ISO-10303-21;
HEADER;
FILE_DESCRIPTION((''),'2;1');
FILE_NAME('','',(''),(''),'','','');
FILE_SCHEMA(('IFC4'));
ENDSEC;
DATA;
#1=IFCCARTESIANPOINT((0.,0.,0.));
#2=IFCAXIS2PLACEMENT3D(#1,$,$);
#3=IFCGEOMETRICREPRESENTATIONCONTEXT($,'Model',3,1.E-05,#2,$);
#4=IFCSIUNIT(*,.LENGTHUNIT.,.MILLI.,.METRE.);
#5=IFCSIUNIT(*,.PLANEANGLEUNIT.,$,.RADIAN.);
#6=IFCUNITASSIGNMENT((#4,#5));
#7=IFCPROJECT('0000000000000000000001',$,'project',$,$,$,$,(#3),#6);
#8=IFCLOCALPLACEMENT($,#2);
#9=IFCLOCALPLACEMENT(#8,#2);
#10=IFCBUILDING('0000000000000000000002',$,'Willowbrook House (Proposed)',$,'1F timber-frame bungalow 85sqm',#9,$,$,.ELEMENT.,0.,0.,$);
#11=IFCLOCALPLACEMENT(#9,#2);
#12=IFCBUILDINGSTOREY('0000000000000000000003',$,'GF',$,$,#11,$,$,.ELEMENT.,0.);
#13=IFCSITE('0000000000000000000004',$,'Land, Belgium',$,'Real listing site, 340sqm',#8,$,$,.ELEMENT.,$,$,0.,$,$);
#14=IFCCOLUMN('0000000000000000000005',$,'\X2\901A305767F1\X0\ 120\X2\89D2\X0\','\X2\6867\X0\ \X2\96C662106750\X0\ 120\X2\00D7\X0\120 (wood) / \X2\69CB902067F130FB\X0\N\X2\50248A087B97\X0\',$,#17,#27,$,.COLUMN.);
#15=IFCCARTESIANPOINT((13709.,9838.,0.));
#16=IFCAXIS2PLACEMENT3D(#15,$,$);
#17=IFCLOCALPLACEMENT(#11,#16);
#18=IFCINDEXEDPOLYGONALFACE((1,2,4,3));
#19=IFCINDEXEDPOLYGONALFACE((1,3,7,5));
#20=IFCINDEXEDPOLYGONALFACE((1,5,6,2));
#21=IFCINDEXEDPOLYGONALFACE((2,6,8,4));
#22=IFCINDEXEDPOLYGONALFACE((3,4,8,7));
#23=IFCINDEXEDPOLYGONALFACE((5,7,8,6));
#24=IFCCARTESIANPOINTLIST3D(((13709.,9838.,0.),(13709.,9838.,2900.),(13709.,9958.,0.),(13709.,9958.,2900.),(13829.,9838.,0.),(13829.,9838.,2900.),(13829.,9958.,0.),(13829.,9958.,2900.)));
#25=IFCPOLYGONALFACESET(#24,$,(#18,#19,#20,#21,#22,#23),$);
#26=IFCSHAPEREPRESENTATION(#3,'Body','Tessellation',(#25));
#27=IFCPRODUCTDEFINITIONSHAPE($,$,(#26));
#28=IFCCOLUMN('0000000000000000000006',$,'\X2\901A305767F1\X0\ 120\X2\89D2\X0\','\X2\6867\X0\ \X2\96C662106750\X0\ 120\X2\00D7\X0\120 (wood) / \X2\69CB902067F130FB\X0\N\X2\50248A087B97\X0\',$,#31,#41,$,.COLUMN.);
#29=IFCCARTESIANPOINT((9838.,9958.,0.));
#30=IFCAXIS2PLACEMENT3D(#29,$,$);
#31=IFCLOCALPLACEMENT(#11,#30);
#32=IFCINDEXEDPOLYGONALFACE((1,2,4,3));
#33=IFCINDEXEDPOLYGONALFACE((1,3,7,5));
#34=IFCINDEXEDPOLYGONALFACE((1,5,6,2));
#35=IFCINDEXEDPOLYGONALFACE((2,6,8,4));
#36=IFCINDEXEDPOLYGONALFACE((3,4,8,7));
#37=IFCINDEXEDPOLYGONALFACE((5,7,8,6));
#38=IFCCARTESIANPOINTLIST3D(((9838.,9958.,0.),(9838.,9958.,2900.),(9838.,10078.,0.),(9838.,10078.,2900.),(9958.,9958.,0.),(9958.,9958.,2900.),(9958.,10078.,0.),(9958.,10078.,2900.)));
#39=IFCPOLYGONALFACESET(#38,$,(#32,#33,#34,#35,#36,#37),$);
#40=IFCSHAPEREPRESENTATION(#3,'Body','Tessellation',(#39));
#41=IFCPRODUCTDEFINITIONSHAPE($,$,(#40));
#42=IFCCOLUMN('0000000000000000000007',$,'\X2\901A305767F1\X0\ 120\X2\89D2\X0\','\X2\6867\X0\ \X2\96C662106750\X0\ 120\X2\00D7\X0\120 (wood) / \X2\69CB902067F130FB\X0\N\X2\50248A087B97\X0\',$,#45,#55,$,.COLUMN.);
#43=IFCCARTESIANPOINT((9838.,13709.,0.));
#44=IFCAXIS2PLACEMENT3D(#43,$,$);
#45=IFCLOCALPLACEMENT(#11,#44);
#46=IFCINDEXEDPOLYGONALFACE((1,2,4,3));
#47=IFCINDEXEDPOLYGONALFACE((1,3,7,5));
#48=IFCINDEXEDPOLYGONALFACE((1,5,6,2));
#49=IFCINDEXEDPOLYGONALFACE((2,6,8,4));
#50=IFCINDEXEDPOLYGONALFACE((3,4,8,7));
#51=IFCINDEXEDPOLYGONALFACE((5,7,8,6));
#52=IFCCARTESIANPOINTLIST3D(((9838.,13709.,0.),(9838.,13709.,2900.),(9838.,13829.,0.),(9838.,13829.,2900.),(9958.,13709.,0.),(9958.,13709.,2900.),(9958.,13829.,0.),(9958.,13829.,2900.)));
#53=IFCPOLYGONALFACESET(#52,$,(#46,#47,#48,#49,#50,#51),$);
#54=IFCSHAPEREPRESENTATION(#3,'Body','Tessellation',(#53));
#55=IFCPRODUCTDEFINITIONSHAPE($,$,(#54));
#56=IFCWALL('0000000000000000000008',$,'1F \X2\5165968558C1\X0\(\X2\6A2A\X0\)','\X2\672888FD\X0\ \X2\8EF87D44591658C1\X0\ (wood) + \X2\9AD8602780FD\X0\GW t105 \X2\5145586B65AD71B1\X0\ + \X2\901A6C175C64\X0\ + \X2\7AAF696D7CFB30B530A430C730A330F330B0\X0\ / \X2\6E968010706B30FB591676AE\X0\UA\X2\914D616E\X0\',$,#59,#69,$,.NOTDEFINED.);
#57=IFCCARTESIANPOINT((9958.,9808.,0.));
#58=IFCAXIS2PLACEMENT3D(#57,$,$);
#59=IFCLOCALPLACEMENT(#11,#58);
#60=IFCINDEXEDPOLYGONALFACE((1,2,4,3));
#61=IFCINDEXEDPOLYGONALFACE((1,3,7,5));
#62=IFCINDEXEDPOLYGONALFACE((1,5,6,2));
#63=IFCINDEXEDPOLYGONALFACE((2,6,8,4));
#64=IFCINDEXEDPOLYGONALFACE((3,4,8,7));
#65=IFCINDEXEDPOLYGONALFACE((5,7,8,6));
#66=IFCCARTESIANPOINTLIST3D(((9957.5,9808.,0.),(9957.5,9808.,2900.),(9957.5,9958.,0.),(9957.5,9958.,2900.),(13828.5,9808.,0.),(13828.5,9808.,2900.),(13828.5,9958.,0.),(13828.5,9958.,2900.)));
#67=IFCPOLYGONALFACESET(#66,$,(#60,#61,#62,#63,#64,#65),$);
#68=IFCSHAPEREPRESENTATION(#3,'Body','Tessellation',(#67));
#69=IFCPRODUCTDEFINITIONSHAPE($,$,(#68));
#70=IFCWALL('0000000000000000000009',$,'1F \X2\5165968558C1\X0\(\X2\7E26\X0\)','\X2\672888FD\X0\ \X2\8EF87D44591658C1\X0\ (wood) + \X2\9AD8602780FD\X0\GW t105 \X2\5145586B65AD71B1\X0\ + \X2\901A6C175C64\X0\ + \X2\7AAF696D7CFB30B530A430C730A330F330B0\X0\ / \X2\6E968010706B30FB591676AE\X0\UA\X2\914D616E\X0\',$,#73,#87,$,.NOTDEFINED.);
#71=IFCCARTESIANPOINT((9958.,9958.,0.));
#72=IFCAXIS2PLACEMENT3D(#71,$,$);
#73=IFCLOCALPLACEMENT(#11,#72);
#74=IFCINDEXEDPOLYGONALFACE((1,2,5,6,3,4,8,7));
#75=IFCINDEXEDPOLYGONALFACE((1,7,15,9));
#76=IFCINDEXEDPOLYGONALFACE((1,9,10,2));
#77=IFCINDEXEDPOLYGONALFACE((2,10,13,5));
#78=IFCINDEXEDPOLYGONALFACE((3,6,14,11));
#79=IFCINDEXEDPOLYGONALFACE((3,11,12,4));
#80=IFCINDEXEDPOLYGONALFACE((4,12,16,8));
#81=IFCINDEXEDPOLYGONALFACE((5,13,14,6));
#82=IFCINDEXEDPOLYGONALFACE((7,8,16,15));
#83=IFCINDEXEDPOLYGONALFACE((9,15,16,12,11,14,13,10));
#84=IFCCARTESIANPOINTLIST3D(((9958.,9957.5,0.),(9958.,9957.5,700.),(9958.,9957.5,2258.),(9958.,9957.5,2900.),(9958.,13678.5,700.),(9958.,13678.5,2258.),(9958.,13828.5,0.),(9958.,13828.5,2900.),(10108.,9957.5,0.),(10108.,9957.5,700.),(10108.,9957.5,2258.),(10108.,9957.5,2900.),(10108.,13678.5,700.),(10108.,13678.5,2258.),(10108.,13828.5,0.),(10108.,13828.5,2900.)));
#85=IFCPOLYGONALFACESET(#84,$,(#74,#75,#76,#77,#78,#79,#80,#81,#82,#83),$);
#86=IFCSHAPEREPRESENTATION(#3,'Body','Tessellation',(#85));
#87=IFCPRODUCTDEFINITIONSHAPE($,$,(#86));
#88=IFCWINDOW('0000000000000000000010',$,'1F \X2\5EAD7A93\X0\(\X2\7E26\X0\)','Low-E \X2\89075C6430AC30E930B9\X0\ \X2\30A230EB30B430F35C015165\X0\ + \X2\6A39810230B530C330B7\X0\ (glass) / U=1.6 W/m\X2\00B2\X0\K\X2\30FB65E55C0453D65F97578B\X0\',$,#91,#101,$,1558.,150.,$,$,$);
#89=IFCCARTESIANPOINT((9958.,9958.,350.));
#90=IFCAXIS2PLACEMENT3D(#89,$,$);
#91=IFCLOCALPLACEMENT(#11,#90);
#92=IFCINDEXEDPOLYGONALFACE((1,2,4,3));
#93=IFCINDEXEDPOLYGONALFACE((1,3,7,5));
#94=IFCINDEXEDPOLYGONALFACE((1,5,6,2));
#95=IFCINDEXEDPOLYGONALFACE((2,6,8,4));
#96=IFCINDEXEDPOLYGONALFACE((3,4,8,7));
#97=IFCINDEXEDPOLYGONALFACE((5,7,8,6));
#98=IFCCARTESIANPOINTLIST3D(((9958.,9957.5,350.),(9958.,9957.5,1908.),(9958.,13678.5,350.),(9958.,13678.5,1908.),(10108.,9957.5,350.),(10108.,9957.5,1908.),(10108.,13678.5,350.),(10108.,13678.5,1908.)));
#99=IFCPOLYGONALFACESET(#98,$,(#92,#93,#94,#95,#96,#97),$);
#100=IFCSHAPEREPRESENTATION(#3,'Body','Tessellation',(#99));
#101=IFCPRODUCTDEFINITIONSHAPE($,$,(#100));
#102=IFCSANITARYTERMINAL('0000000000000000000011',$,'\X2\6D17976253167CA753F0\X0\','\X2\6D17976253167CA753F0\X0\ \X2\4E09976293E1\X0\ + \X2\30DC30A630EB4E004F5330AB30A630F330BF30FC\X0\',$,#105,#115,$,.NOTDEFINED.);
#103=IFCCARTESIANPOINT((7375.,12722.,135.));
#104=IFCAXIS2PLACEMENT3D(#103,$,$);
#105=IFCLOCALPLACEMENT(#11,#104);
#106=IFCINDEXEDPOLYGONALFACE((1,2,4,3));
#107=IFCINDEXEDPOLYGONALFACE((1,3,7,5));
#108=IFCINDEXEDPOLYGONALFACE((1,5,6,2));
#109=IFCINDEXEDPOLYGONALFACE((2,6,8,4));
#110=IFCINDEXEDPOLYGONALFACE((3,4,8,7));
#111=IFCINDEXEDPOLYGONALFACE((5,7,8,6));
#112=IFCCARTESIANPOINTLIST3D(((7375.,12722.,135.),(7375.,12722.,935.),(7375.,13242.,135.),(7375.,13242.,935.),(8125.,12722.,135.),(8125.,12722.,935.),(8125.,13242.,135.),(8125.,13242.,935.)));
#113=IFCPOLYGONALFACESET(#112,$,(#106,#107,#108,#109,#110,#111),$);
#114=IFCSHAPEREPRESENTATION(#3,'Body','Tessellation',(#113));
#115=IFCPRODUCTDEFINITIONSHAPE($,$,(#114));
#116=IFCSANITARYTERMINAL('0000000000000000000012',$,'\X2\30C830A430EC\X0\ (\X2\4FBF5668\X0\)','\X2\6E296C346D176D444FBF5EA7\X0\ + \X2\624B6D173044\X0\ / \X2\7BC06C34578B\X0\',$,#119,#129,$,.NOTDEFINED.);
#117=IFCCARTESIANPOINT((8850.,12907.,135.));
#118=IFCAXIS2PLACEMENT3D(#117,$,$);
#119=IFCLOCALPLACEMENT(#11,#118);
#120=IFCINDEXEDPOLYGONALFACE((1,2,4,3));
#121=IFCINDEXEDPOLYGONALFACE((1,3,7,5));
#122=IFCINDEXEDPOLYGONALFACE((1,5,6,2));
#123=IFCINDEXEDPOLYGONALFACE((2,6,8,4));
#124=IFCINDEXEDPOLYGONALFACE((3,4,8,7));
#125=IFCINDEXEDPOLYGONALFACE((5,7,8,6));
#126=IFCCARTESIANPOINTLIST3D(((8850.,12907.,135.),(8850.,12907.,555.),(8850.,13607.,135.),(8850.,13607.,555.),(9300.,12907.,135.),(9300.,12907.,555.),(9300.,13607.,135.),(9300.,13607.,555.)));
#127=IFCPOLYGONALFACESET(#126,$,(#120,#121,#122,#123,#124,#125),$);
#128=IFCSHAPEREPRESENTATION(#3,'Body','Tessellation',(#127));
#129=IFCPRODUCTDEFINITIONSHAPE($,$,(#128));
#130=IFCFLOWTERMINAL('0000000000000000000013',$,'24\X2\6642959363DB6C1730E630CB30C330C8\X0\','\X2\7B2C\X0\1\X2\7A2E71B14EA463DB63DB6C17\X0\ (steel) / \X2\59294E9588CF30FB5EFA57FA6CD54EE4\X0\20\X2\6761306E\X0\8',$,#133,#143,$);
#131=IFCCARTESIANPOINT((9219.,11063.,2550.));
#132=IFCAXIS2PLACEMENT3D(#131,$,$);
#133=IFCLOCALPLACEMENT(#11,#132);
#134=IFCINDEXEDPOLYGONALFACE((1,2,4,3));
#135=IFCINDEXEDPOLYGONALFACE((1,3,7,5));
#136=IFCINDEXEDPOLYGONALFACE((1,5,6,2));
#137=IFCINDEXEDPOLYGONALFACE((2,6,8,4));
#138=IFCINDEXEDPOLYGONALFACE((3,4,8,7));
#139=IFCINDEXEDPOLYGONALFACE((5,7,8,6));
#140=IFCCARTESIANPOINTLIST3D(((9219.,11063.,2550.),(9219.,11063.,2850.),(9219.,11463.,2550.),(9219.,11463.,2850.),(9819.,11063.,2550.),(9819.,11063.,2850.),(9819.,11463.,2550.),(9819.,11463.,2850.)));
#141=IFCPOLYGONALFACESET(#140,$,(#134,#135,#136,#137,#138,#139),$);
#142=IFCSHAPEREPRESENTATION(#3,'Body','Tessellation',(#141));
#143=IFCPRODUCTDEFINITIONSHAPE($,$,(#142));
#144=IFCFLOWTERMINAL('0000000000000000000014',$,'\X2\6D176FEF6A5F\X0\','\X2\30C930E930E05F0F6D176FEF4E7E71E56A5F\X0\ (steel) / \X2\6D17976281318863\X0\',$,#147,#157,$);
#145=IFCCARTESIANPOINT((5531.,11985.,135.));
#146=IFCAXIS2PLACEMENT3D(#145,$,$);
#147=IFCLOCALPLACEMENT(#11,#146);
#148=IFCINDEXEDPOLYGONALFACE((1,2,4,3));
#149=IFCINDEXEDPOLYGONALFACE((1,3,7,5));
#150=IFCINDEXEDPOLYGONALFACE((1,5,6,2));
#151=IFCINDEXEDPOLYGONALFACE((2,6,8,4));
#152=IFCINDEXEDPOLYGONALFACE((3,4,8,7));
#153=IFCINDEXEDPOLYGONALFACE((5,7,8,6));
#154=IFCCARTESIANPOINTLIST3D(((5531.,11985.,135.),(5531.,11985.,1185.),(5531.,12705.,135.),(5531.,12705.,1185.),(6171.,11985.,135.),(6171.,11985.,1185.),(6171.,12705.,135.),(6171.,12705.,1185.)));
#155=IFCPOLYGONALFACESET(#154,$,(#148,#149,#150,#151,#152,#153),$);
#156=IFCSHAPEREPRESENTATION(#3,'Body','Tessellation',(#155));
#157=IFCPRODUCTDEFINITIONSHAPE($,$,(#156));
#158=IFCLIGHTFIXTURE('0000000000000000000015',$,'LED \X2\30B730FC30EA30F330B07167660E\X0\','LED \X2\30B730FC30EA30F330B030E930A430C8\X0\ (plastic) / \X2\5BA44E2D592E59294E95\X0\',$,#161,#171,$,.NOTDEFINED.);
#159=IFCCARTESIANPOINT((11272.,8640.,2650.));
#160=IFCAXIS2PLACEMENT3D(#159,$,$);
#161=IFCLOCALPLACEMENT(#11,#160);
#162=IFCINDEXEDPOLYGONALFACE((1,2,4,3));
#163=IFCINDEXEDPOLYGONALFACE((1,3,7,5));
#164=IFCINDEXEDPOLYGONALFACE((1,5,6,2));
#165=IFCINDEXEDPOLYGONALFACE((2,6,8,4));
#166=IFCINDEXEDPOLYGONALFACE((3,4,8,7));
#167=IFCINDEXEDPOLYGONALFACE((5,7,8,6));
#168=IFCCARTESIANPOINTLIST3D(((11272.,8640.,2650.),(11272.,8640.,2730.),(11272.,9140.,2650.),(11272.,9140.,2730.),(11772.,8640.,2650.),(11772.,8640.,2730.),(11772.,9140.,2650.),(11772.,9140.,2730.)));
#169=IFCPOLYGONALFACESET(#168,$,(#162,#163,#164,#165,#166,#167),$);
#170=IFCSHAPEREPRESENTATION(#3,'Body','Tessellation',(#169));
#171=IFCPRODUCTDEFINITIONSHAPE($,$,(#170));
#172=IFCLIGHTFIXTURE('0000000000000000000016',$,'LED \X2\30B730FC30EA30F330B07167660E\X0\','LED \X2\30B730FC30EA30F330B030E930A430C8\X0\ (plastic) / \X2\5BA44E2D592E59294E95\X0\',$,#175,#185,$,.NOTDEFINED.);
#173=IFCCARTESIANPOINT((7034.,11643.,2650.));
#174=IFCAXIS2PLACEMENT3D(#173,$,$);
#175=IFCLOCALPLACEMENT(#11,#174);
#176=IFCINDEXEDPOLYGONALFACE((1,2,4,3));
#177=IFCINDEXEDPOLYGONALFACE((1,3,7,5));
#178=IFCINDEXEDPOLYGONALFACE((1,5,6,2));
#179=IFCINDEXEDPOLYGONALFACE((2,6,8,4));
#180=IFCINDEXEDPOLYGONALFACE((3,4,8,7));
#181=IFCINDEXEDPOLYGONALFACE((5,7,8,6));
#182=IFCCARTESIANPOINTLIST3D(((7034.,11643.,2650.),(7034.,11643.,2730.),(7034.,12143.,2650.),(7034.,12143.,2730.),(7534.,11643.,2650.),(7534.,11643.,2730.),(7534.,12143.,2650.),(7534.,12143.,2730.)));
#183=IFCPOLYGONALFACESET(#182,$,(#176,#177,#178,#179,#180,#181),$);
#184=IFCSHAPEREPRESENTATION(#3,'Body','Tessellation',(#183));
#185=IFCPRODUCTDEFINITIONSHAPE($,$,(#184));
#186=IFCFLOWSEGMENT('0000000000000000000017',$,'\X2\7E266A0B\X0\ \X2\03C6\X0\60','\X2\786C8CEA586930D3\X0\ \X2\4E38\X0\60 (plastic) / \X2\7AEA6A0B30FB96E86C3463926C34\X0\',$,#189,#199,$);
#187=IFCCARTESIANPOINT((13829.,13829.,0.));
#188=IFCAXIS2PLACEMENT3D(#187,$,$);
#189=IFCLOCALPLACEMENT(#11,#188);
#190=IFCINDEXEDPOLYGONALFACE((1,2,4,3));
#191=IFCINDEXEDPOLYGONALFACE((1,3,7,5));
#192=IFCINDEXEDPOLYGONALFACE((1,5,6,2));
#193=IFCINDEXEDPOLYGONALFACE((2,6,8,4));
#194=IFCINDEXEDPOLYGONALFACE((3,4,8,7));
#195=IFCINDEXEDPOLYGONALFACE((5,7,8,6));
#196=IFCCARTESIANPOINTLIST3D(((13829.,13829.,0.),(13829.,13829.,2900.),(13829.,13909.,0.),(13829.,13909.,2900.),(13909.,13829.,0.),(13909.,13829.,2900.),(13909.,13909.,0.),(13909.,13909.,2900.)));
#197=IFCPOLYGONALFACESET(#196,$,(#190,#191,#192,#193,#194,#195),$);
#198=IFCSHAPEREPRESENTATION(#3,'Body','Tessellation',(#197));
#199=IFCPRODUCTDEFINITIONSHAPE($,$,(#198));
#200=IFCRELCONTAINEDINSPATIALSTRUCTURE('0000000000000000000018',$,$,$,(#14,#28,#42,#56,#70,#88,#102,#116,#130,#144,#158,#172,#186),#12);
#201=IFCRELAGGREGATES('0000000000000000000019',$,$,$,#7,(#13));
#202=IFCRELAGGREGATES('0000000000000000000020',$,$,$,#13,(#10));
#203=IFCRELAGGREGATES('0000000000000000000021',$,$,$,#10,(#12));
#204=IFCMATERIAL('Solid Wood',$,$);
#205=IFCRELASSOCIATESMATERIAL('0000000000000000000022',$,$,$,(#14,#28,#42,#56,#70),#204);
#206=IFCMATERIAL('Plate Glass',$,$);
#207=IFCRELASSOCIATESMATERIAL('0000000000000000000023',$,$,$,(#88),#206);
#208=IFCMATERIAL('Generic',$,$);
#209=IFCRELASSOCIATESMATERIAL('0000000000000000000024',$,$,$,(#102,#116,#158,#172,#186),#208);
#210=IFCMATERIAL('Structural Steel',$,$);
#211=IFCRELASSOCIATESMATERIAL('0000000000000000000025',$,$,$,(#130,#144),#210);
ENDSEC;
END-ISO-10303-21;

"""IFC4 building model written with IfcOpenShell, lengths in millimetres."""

from ifc_helpers import new_model, si_unit, frame, frame_2d, origin, place, context, project, spatial, rectangle, extrude, material, element, fill, save


model = new_model("IFC4")

# Units and contexts
model_context = context("Model", 3, precision=1e-05, world=origin())
ifc_project = project(units=[si_unit("LENGTHUNIT", "METRE", prefix="MILLI"), si_unit("PLANEANGLEUNIT", "RADIAN")], contexts=[model_context])

# Site, building, storey
site_placement = place(None, origin())
site = spatial("IfcSite", under=ifc_project, at=site_placement, Name="Land, Belgium", ObjectType="Real listing site, 340sqm", CompositionType="ELEMENT", RefElevation=0.0)
building_placement = place(site_placement, origin())
building = spatial("IfcBuilding", under=site, at=building_placement, Name="Willowbrook House (Proposed)", ObjectType="1F timber-frame bungalow 85sqm", CompositionType="ELEMENT", ElevationOfRefHeight=0.0, ElevationOfTerrain=0.0)
storey_placement = place(building_placement, origin())
storey = spatial("IfcBuildingStorey", under=building, at=storey_placement, Name="GF", CompositionType="ELEMENT", Elevation=0.0)

# Columns
ifc_material_1 = material(Name="Solid Wood")
column_1_placement = place(storey_placement, frame((13709.0, 9838.0, 0.0)))
element("IfcColumn", 1, at=column_1_placement, inside=storey, material=ifc_material_1, Name="通し柱 120角", Description="桧 集成材 120×120 (wood) / 構造柱・N値計算", PredefinedType="COLUMN", context=model_context, shape_type="SweptSolid", body=[
    extrude(rectangle(XDim=120.0, YDim=120.0, at=frame_2d((60.0, 60.0))), frame((13709.0, 9838.0, 0.0)), (0.0, 0.0, 1.0), 2900.0),
])
column_2_placement = place(storey_placement, frame((9838.0, 9958.0, 0.0)))
element("IfcColumn", 2, at=column_2_placement, inside=storey, material=ifc_material_1, Name="通し柱 120角", Description="桧 集成材 120×120 (wood) / 構造柱・N値計算", PredefinedType="COLUMN", context=model_context, shape_type="SweptSolid", body=[
    extrude(rectangle(XDim=120.0, YDim=120.0, at=frame_2d((60.0, 60.0))), frame((9838.0, 9958.0, 0.0)), (0.0, 0.0, 1.0), 2900.0),
])
column_3_placement = place(storey_placement, frame((9838.0, 13709.0, 0.0)))
element("IfcColumn", 3, at=column_3_placement, inside=storey, material=ifc_material_1, Name="通し柱 120角", Description="桧 集成材 120×120 (wood) / 構造柱・N値計算", PredefinedType="COLUMN", context=model_context, shape_type="SweptSolid", body=[
    extrude(rectangle(XDim=120.0, YDim=120.0, at=frame_2d((60.0, 60.0))), frame((9838.0, 13709.0, 0.0)), (0.0, 0.0, 1.0), 2900.0),
])

# Wall
wall_1_placement = place(storey_placement, frame((9958.0, 9808.0, 0.0)))
element("IfcWall", 4, at=wall_1_placement, inside=storey, material=ifc_material_1, Name="1F 入隅壁(横)", Description="木製 軸組外壁 (wood) + 高性能GW t105 充填断熱 + 通気層 + 窯業系サイディング / 準耐火・外皮UA配慮", PredefinedType="NOTDEFINED", context=model_context, shape_type="SweptSolid", body=[
    extrude(rectangle(XDim=3871.0, YDim=150.0, at=frame_2d((1935.0, 75.0))), frame((9958.0, 9808.0, 0.0)), (0.0, 0.0, 1.0), 2900.0),
])

# Wall, opening, window
wall_2_placement = place(storey_placement, frame((9958.0, 9958.0, 0.0)))
wall_2 = element("IfcWall", 5, at=wall_2_placement, inside=storey, material=ifc_material_1, Name="1F 入隅壁(縦)", Description="木製 軸組外壁 (wood) + 高性能GW t105 充填断熱 + 通気層 + 窯業系サイディング / 準耐火・外皮UA配慮", PredefinedType="NOTDEFINED", context=model_context, shape_type="SweptSolid", body=[
    extrude(rectangle(XDim=150.0, YDim=3871.0, at=frame_2d((75.0, 1935.0))), frame((9958.0, 9958.0, 0.0)), (0.0, 0.0, 1.0), 2900.0),
])
opening_placement = place(storey_placement, frame((9958.0, 9958.0, 350.0)))
opening = element("IfcOpeningElement", 6, at=opening_placement, cuts=wall_2, PredefinedType="NOTDEFINED", context=model_context, shape_type="SweptSolid", body=[
    extrude(rectangle(XDim=150.0, YDim=3721.0, at=frame_2d((75.0, 1860.0))), frame((9958.0, 9958.0, 350.0)), (0.0, 0.0, 1.0), 1558.0),
])
ifc_material_2 = material(Name="Plate Glass")
window_placement = place(storey_placement, frame((9958.0, 9958.0, 350.0)))
window = element("IfcWindow", 7, at=window_placement, inside=storey, material=ifc_material_2, Name="1F 庭窓(縦)", Description="Low-E 複層ガラス アルゴン封入 + 樹脂サッシ (glass) / U=1.6 W/m²K・日射取得型", OverallHeight=1558.0, OverallWidth=150.0, context=model_context, shape_type="SweptSolid", body=[
    extrude(rectangle(XDim=150.0, YDim=3721.0, at=frame_2d((75.0, 1860.0))), frame((9958.0, 9958.0, 350.0)), (0.0, 0.0, 1.0), 1558.0),
])
fill(opening, window)

# Sanitary terminals
ifc_material_3 = material(Name="Generic")
sanitary_terminal_1_placement = place(storey_placement, frame((7375.0, 12722.0, 135.0)))
element("IfcSanitaryTerminal", 8, at=sanitary_terminal_1_placement, inside=storey, material=ifc_material_3, Name="洗面化粧台", Description="洗面化粧台 三面鏡 + ボウル一体カウンター", PredefinedType="NOTDEFINED", context=model_context, shape_type="SweptSolid", body=[
    extrude(rectangle(XDim=750.0, YDim=520.0, at=frame_2d((375.0, 260.0))), frame((7375.0, 12722.0, 135.0)), (0.0, 0.0, 1.0), 800.0),
])
sanitary_terminal_2_placement = place(storey_placement, frame((8850.0, 12907.0, 135.0)))
element("IfcSanitaryTerminal", 9, at=sanitary_terminal_2_placement, inside=storey, material=ifc_material_3, Name="トイレ (便器)", Description="温水洗浄便座 + 手洗い / 節水型", PredefinedType="NOTDEFINED", context=model_context, shape_type="SweptSolid", body=[
    extrude(rectangle(XDim=450.0, YDim=700.0, at=frame_2d((225.0, 350.0))), frame((8850.0, 12907.0, 135.0)), (0.0, 0.0, 1.0), 420.0),
])

# Flow terminals
ifc_material_4 = material(Name="Structural Steel")
flow_terminal_1_placement = place(storey_placement, frame((9219.0, 11063.0, 2550.0)))
element("IfcFlowTerminal", 10, at=flow_terminal_1_placement, inside=storey, material=ifc_material_4, Name="24時間換気ユニット", Description="第1種熱交換換気 (steel) / 天井裏・建基法令20条の8", context=model_context, shape_type="SweptSolid", body=[
    extrude(rectangle(XDim=600.0, YDim=400.0, at=frame_2d((300.0, 200.0))), frame((9219.0, 11063.0, 2550.0)), (0.0, 0.0, 1.0), 300.0),
])
flow_terminal_2_placement = place(storey_placement, frame((5531.0, 11985.0, 135.0)))
element("IfcFlowTerminal", 11, at=flow_terminal_2_placement, inside=storey, material=ifc_material_4, Name="洗濯機", Description="ドラム式洗濯乾燥機 (steel) / 洗面脱衣", context=model_context, shape_type="SweptSolid", body=[
    extrude(rectangle(XDim=640.0, YDim=720.0, at=frame_2d((320.0, 360.0))), frame((5531.0, 11985.0, 135.0)), (0.0, 0.0, 1.0), 1050.0),
])

# Light fixtures
light_fixture_1_placement = place(storey_placement, frame((11272.0, 8640.0, 2650.0)))
element("IfcLightFixture", 12, at=light_fixture_1_placement, inside=storey, material=ifc_material_3, Name="LED シーリング照明", Description="LED シーリングライト (plastic) / 室中央天井", PredefinedType="NOTDEFINED", context=model_context, shape_type="SweptSolid", body=[
    extrude(rectangle(XDim=500.0, YDim=500.0, at=frame_2d((250.0, 250.0))), frame((11272.0, 8640.0, 2650.0)), (0.0, 0.0, 1.0), 80.0),
])
light_fixture_2_placement = place(storey_placement, frame((7034.0, 11643.0, 2650.0)))
element("IfcLightFixture", 13, at=light_fixture_2_placement, inside=storey, material=ifc_material_3, Name="LED シーリング照明", Description="LED シーリングライト (plastic) / 室中央天井", PredefinedType="NOTDEFINED", context=model_context, shape_type="SweptSolid", body=[
    extrude(rectangle(XDim=500.0, YDim=500.0, at=frame_2d((250.0, 250.0))), frame((7034.0, 11643.0, 2650.0)), (0.0, 0.0, 1.0), 80.0),
])

# Flow segment
flow_segment_placement = place(storey_placement, frame((13829.0, 13829.0, 0.0)))
element("IfcFlowSegment", 14, at=flow_segment_placement, inside=storey, material=ifc_material_3, Name="縦樋 φ60", Description="硬質塩ビ 丸60 (plastic) / 竪樋・雨水排水", context=model_context, shape_type="SweptSolid", body=[
    extrude(rectangle(XDim=80.0, YDim=80.0, at=frame_2d((40.0, 40.0))), frame((13829.0, 13829.0, 0.0)), (0.0, 0.0, 1.0), 2900.0),
])

save(model, "model.ifc")
